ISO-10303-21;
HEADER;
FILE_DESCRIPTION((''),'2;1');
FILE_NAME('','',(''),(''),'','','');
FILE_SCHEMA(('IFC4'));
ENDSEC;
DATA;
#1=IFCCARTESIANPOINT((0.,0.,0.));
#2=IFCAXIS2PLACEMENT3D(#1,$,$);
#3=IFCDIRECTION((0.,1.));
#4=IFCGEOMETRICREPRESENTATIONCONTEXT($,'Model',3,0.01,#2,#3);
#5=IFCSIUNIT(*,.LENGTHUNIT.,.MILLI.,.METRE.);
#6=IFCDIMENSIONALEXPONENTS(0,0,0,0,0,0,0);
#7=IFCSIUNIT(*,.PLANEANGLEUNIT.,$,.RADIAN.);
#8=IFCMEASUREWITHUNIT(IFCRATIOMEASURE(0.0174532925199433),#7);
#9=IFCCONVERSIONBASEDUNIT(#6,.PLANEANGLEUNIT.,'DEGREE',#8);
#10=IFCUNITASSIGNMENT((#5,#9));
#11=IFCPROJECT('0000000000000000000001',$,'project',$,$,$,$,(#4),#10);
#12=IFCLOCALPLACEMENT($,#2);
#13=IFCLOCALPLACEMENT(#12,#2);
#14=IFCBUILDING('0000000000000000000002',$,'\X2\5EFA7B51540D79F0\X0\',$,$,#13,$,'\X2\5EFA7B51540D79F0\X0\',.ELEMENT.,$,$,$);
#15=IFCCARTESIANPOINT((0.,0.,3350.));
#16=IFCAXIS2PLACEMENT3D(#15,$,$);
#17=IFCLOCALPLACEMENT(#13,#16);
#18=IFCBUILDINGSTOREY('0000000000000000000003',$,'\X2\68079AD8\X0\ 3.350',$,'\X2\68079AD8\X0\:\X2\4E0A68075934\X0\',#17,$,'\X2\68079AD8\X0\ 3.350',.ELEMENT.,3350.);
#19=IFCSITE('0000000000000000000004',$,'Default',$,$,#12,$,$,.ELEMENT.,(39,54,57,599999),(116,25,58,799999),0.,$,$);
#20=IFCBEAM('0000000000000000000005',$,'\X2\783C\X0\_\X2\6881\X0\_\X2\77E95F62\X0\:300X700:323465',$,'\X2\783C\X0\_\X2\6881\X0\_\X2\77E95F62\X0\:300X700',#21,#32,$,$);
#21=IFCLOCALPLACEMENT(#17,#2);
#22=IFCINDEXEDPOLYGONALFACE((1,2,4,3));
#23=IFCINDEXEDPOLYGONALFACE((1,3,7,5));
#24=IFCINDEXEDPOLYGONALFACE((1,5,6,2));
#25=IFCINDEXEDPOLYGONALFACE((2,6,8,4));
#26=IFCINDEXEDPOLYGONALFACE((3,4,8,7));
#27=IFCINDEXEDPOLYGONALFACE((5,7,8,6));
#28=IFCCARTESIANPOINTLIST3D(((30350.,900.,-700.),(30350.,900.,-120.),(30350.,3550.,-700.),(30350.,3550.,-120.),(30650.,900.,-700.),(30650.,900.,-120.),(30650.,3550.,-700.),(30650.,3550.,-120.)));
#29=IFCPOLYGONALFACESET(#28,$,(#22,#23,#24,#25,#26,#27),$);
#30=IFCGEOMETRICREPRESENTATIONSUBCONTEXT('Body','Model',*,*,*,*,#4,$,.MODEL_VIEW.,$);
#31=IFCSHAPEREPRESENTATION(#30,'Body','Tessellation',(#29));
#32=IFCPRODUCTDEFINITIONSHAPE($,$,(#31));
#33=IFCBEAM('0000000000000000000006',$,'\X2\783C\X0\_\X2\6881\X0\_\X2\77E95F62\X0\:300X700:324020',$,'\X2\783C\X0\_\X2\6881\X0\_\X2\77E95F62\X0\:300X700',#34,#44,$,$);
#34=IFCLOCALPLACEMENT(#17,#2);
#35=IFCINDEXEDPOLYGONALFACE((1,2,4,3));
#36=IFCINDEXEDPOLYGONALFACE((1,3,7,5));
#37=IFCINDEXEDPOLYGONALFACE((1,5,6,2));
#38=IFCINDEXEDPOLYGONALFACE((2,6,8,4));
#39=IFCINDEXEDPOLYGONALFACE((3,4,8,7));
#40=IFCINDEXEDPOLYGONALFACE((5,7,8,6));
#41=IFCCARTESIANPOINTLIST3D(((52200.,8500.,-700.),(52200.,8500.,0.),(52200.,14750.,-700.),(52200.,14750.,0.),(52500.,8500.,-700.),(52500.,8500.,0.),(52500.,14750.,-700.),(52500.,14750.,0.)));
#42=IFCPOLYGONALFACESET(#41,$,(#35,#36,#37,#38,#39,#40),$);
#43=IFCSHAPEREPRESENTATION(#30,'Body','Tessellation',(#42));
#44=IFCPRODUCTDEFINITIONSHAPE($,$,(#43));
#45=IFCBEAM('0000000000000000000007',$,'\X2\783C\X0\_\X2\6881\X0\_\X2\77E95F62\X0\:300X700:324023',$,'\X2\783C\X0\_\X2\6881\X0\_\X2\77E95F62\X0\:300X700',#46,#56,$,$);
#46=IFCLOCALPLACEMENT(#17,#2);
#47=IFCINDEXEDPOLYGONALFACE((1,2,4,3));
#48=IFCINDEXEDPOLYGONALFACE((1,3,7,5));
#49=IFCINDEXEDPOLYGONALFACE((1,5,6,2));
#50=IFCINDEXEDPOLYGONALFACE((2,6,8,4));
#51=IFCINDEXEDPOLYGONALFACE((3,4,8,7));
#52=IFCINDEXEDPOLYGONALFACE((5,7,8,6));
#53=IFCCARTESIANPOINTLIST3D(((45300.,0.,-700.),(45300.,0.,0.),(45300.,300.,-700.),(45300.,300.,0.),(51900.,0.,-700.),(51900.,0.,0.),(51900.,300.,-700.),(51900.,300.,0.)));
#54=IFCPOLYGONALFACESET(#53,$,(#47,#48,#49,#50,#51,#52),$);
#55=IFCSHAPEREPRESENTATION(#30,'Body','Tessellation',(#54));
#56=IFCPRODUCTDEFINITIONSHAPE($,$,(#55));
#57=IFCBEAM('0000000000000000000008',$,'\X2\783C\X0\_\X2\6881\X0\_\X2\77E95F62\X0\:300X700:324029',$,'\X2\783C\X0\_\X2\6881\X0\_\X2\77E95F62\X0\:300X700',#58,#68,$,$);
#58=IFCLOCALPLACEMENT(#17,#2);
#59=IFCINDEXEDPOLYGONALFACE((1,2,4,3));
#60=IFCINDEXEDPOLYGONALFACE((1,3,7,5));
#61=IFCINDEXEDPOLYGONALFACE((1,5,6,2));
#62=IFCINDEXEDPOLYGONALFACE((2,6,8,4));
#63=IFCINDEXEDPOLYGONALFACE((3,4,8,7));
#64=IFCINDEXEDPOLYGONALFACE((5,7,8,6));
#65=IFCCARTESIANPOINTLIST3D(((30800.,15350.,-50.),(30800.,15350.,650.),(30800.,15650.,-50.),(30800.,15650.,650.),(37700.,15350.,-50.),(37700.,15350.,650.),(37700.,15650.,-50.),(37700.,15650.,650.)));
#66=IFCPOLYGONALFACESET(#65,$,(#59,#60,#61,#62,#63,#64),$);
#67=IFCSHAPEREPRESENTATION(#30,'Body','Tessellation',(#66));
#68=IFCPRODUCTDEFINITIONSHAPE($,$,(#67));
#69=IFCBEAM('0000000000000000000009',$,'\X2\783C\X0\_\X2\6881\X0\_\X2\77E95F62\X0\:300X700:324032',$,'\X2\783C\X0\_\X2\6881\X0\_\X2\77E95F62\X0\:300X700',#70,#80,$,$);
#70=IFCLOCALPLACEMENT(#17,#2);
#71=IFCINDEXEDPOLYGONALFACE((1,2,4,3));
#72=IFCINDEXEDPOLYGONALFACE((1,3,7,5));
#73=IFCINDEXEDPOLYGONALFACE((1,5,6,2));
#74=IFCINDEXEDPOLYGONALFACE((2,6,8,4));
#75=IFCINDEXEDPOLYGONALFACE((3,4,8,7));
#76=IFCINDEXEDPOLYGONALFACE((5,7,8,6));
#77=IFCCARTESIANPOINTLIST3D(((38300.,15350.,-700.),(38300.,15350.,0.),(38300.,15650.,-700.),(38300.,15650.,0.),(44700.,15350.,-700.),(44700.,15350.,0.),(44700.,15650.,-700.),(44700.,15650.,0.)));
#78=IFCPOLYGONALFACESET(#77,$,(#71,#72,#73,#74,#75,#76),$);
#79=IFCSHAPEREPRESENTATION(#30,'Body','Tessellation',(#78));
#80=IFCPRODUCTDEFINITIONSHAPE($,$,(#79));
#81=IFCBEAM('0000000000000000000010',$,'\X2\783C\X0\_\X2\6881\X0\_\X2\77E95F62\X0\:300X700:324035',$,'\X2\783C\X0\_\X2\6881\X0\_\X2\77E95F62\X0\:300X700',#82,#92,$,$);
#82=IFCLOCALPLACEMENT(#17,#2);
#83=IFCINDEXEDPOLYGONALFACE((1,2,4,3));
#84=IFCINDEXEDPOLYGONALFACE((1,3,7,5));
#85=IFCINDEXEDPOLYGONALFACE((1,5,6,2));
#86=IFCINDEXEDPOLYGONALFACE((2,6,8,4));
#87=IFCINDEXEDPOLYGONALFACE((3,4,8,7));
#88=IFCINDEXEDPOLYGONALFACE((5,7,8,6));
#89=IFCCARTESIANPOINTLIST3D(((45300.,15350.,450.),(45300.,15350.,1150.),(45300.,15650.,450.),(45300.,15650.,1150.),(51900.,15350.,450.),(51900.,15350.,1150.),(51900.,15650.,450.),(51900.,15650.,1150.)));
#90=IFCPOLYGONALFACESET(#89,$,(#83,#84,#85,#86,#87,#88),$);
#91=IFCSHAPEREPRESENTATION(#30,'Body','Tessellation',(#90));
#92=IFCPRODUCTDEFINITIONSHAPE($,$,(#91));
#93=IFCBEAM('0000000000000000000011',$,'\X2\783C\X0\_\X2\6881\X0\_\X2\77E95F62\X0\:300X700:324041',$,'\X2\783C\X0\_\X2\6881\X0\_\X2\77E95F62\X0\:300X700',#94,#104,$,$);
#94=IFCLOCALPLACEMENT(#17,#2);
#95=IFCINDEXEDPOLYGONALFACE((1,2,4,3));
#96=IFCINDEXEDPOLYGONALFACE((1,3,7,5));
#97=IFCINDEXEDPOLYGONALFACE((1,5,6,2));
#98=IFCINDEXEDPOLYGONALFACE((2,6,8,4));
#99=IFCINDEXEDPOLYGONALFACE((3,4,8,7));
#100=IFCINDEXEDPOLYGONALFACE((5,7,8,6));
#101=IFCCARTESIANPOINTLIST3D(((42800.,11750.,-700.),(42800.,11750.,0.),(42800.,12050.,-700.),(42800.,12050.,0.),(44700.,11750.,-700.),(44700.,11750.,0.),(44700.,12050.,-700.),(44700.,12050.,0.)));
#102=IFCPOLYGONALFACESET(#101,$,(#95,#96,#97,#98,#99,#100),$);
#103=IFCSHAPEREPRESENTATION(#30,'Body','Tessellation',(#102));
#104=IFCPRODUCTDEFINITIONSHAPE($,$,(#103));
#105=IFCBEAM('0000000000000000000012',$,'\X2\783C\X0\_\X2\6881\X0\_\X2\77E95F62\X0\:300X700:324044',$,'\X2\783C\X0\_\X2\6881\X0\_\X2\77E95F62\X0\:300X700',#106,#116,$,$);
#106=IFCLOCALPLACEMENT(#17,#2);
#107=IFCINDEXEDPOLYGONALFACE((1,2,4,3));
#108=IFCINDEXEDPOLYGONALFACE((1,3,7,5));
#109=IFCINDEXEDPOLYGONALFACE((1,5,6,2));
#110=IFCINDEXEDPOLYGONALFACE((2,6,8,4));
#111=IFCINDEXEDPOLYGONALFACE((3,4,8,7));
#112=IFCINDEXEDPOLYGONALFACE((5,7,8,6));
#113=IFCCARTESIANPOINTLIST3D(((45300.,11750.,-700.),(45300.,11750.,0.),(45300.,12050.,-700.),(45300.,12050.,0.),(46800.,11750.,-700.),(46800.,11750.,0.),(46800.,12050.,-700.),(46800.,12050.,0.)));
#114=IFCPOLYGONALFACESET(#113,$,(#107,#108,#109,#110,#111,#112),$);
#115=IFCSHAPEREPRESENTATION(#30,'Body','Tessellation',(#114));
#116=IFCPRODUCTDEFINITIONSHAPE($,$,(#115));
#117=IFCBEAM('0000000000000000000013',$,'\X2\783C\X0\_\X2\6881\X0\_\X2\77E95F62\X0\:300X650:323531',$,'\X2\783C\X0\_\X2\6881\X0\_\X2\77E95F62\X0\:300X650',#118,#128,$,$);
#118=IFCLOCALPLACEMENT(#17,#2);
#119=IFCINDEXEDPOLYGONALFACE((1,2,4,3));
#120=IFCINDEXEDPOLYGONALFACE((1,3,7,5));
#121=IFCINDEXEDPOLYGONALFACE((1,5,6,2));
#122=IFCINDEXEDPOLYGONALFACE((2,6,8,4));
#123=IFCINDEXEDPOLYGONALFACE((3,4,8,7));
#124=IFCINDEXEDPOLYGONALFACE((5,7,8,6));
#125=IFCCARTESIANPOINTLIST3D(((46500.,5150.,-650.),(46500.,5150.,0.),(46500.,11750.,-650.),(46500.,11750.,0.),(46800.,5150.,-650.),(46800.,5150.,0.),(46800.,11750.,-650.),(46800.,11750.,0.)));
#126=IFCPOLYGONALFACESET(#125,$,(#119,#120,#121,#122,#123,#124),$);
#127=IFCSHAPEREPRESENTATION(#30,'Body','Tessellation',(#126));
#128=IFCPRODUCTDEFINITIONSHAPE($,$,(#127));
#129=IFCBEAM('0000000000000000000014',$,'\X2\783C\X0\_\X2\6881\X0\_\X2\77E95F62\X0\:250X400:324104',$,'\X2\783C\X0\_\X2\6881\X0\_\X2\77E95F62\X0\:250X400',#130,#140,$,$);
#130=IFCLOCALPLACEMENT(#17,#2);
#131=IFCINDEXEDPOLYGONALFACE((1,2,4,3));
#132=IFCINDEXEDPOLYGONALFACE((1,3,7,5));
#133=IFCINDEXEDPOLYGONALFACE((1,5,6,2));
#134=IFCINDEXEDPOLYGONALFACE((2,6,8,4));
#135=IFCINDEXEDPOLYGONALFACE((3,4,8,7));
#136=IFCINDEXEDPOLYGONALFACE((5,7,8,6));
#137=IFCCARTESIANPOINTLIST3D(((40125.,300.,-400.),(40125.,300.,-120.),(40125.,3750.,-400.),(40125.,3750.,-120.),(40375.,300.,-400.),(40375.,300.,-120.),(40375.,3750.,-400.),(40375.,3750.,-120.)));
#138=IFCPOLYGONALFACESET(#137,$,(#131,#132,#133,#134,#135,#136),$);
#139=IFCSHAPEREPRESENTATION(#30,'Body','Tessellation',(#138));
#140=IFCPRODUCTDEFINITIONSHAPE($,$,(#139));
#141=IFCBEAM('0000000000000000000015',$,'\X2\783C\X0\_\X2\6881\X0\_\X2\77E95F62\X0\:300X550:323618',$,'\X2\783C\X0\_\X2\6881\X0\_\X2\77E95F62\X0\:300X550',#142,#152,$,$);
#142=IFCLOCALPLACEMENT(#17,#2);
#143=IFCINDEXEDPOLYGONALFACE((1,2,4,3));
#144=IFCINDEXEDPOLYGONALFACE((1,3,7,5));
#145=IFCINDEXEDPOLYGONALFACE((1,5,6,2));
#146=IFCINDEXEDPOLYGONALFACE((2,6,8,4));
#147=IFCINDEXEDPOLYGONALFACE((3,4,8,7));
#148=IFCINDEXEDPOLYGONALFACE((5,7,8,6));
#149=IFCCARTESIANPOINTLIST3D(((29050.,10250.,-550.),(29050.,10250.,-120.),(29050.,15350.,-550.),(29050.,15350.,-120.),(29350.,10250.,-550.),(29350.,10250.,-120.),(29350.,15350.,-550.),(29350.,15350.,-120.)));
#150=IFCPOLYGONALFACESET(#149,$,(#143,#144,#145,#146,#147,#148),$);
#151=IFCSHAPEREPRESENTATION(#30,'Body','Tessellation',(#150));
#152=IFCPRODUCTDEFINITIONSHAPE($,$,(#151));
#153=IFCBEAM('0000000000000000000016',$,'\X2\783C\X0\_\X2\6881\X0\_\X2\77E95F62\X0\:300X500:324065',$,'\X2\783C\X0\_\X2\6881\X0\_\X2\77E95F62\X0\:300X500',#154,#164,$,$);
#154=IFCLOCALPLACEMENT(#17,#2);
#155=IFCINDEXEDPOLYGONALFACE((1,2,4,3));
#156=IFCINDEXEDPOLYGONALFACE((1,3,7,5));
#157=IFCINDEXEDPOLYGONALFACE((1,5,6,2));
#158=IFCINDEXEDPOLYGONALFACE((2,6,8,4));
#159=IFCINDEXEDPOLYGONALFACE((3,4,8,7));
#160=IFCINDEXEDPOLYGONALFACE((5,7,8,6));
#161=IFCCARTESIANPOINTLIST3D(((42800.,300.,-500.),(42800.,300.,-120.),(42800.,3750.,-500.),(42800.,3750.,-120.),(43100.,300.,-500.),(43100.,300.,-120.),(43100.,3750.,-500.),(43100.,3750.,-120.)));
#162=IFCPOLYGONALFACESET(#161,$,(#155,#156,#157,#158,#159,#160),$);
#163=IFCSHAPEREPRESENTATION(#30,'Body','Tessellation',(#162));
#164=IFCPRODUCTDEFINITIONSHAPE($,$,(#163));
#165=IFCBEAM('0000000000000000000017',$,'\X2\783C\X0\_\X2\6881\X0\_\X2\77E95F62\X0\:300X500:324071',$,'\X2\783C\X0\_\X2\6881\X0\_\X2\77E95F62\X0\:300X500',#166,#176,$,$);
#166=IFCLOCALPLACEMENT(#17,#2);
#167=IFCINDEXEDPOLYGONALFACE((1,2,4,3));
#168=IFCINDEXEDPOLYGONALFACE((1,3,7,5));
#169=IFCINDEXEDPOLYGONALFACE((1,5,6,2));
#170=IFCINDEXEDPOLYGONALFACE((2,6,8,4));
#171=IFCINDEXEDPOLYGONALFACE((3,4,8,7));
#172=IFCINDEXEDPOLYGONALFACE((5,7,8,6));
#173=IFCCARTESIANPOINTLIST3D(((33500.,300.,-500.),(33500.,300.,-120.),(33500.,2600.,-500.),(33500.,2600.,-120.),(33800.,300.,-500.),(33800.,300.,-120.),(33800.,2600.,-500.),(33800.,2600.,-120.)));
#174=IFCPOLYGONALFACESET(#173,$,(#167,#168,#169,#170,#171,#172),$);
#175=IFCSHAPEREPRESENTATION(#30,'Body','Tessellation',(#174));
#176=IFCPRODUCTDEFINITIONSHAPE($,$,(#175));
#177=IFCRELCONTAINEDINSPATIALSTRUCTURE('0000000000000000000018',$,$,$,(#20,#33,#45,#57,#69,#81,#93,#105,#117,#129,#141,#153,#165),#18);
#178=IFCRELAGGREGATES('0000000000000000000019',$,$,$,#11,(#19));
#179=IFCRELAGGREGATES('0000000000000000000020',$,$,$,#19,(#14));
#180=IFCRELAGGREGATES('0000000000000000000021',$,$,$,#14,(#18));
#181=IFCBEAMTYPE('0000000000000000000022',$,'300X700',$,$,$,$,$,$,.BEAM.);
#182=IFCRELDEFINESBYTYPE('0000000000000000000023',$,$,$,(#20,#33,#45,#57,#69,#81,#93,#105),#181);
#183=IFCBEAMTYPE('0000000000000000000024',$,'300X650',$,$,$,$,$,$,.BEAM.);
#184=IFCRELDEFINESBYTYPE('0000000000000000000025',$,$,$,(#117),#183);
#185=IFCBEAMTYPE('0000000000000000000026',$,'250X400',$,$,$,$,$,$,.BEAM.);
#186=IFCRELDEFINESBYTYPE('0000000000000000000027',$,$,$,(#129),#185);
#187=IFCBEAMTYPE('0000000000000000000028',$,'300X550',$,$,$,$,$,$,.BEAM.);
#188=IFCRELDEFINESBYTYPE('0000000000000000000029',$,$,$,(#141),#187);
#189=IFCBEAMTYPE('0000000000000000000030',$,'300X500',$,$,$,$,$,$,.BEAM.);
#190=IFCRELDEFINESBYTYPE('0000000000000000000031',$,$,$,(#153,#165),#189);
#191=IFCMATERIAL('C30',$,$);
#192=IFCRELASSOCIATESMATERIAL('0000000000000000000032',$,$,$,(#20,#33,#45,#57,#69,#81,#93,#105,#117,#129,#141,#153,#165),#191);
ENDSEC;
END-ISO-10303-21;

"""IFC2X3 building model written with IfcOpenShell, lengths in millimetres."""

from ifc_helpers import new_model, entity, si_unit, converted_unit, direction, frame, frame_2d, origin, origin_2d_with_axis, place, context, subcontext, project, spatial, rectangle, extrude, material, type_object, element, save


model = new_model("IFC2X3")

# Units and contexts
model_context = context("Model", 3, precision=0.01, world=origin(), true_north=direction((0.0, 1.0)))
body_context = subcontext(model_context, "Body", "Model", "MODEL_VIEW")
ifc_project = project(units=[si_unit("LENGTHUNIT", "METRE", prefix="MILLI"), converted_unit("PLANEANGLEUNIT", "DEGREE", entity("IfcRatioMeasure", 0.0174532925199433), si_unit("PLANEANGLEUNIT", "RADIAN"), dimensions=[0, 0, 0, 0, 0, 0, 0])], contexts=[model_context])

# Site, building, storey
site_placement = place(None, origin())
site = spatial("IfcSite", under=ifc_project, at=site_placement, Name="Default", CompositionType="ELEMENT", RefLatitude=(39, 54, 57, 599999), RefLongitude=(116, 25, 58, 799999), RefElevation=0.0)
building_placement = place(site_placement, origin())
building = spatial("IfcBuilding", under=site, at=building_placement, Name="建筑名称", LongName="建筑名称", CompositionType="ELEMENT")
storey_placement = place(building_placement, frame((0.0, 0.0, 3350.0)))
storey = spatial("IfcBuildingStorey", under=building, at=storey_placement, Name="标高 3.350", ObjectType="标高:上标头", LongName="标高 3.350", CompositionType="ELEMENT", Elevation=3350.0)

# Beams
ifc_material_1 = material(Name="C30")
beam_type_1 = type_object("IfcBeamType", Name="300X700", PredefinedType="BEAM")
beam_1_placement = place(storey_placement, frame((30500.0, 150.0, 0.0), z_axis=(0.0, 0.0, 1.0), x_axis=(0.0, 1.0, 0.0)))
element("IfcBeam", 1, at=beam_1_placement, inside=storey, type_object=beam_type_1, material=ifc_material_1, Name="砼_梁_矩形:300X700:323465", ObjectType="砼_梁_矩形:300X700", context=body_context, shape_type="SweptSolid", body=[
    extrude(rectangle(XDim=580.0, YDim=300.0, at=frame_2d((0.0, 0.0), x_axis=(1.0, 0.0))), frame((750.0, 0.0, -410.0), z_axis=(1.0, 0.0, 0.0), x_axis=(0.0, 0.0, -1.0)), (0.0, 0.0, 1.0), 2650.0),
])
beam_2_placement = place(storey_placement, frame((52500.0, 8150.0, 0.0), z_axis=(0.0, 0.0, 1.0), x_axis=(0.0, 1.0, 0.0)))
element("IfcBeam", 2, at=beam_2_placement, inside=storey, type_object=beam_type_1, material=ifc_material_1, Name="砼_梁_矩形:300X700:324020", ObjectType="砼_梁_矩形:300X700", context=body_context, shape_type="SweptSolid", body=[
    extrude(rectangle(XDim=700.0, YDim=300.0, at=origin_2d_with_axis()), frame((350.0, 150.0, -350.0), z_axis=(1.0, 0.0, 0.0), x_axis=(0.0, 0.0, -1.0)), (0.0, 0.0, 1.0), 6250.0),
])
beam_3_placement = place(storey_placement, frame((45000.0, 0.0, 0.0)))
element("IfcBeam", 3, at=beam_3_placement, inside=storey, type_object=beam_type_1, material=ifc_material_1, Name="砼_梁_矩形:300X700:324023", ObjectType="砼_梁_矩形:300X700", context=body_context, shape_type="SweptSolid", body=[
    extrude(rectangle(XDim=700.0, YDim=300.0, at=origin_2d_with_axis()), frame((300.0, 150.0, -350.0), z_axis=(1.0, 0.0, 0.0), x_axis=(0.0, 0.0, -1.0)), (0.0, 0.0, 1.0), 6600.0),
])
beam_4_placement = place(storey_placement, frame((30500.0, 15650.0, 0.0)))
element("IfcBeam", 4, at=beam_4_placement, inside=storey, type_object=beam_type_1, material=ifc_material_1, Name="砼_梁_矩形:300X700:324029", ObjectType="砼_梁_矩形:300X700", context=body_context, shape_type="SweptSolid", body=[
    extrude(rectangle(XDim=700.0, YDim=300.0, at=frame_2d((0.0, 0.0), x_axis=(1.0, 0.0))), frame((300.0, -150.0, 300.0), z_axis=(1.0, 0.0, 0.0), x_axis=(0.0, 0.0, -1.0)), (0.0, 0.0, 1.0), 6900.0),
])
beam_5_placement = place(storey_placement, frame((38000.0, 15650.0, 0.0)))
element("IfcBeam", 5, at=beam_5_placement, inside=storey, type_object=beam_type_1, material=ifc_material_1, Name="砼_梁_矩形:300X700:324032", ObjectType="砼_梁_矩形:300X700", context=body_context, shape_type="SweptSolid", body=[
    extrude(rectangle(XDim=700.0, YDim=300.0, at=origin_2d_with_axis()), frame((300.0, -150.0, -350.0), z_axis=(1.0, 0.0, 0.0), x_axis=(0.0, 0.0, -1.0)), (0.0, 0.0, 1.0), 6400.0),
])
beam_6_placement = place(storey_placement, frame((45000.0, 15650.0, 0.0)))
element("IfcBeam", 6, at=beam_6_placement, inside=storey, type_object=beam_type_1, material=ifc_material_1, Name="砼_梁_矩形:300X700:324035", ObjectType="砼_梁_矩形:300X700", context=body_context, shape_type="SweptSolid", body=[
    extrude(rectangle(XDim=700.0, YDim=300.0, at=frame_2d((0.0, 0.0), x_axis=(1.0, 0.0))), frame((300.0, -150.0, 800.0), z_axis=(1.0, 0.0, 0.0), x_axis=(0.0, 0.0, -1.0)), (0.0, 0.0, 1.0), 6600.0),
])
beam_7_placement = place(storey_placement, frame((42800.0, 12050.0, 0.0)))
element("IfcBeam", 7, at=beam_7_placement, inside=storey, type_object=beam_type_1, material=ifc_material_1, Name="砼_梁_矩形:300X700:324041", ObjectType="砼_梁_矩形:300X700", context=body_context, shape_type="SweptSolid", body=[
    extrude(rectangle(XDim=700.0, YDim=300.0, at=frame_2d((0.0, 0.0), x_axis=(1.0, 0.0))), frame((0.0, -150.0, -350.0), z_axis=(1.0, 0.0, 0.0), x_axis=(0.0, 0.0, -1.0)), (0.0, 0.0, 1.0), 1900.0),
])
beam_8_placement = place(storey_placement, frame((45000.0, 12050.0, 0.0)))
element("IfcBeam", 8, at=beam_8_placement, inside=storey, type_object=beam_type_1, material=ifc_material_1, Name="砼_梁_矩形:300X700:324044", ObjectType="砼_梁_矩形:300X700", context=body_context, shape_type="SweptSolid", body=[
    extrude(rectangle(XDim=700.0, YDim=300.0, at=frame_2d((0.0, 0.0), x_axis=(1.0, 0.0))), frame((300.0, -150.0, -350.0), z_axis=(1.0, 0.0, 0.0), x_axis=(0.0, 0.0, -1.0)), (0.0, 0.0, 1.0), 1500.0),
])
beam_type_2 = type_object("IfcBeamType", Name="300X650", PredefinedType="BEAM")
beam_9_placement = place(storey_placement, frame((46800.0, 4850.0, 0.0), z_axis=(0.0, 0.0, 1.0), x_axis=(0.0, 1.0, 0.0)))
element("IfcBeam", 9, at=beam_9_placement, inside=storey, type_object=beam_type_2, material=ifc_material_1, Name="砼_梁_矩形:300X650:323531", ObjectType="砼_梁_矩形:300X650", context=body_context, shape_type="SweptSolid", body=[
    extrude(rectangle(XDim=650.0, YDim=300.0, at=origin_2d_with_axis()), frame((300.0, 150.0, -325.0), z_axis=(1.0, 0.0, 0.0), x_axis=(0.0, 0.0, -1.0)), (0.0, 0.0, 1.0), 6600.0),
])
beam_type_3 = type_object("IfcBeamType", Name="250X400", PredefinedType="BEAM")
beam_10_placement = place(storey_placement, frame((40250.0, 0.0, 0.0), z_axis=(0.0, 0.0, 1.0), x_axis=(0.0, 1.0, 0.0)))
element("IfcBeam", 10, at=beam_10_placement, inside=storey, type_object=beam_type_3, material=ifc_material_1, Name="砼_梁_矩形:250X400:324104", ObjectType="砼_梁_矩形:250X400", context=body_context, shape_type="SweptSolid", body=[
    extrude(rectangle(XDim=280.0, YDim=250.0, at=frame_2d((0.0, 0.0), x_axis=(1.0, 0.0))), frame((300.0, 0.0, -260.0), z_axis=(1.0, 0.0, 0.0), x_axis=(0.0, 0.0, -1.0)), (0.0, 0.0, 1.0), 3450.0),
])
beam_type_4 = type_object("IfcBeamType", Name="300X550", PredefinedType="BEAM")
beam_11_placement = place(storey_placement, frame((29350.0, 9950.0, 0.0), z_axis=(0.0, 0.0, 1.0), x_axis=(0.0, 1.0, 0.0)))
element("IfcBeam", 11, at=beam_11_placement, inside=storey, type_object=beam_type_4, material=ifc_material_1, Name="砼_梁_矩形:300X550:323618", ObjectType="砼_梁_矩形:300X550", context=body_context, shape_type="SweptSolid", body=[
    extrude(rectangle(XDim=430.0, YDim=300.0, at=frame_2d((0.0, 0.0), x_axis=(1.0, 0.0))), frame((300.0, 150.0, -335.0), z_axis=(1.0, 0.0, 0.0), x_axis=(0.0, 0.0, -1.0)), (0.0, 0.0, 1.0), 5100.0),
])
beam_type_5 = type_object("IfcBeamType", Name="300X500", PredefinedType="BEAM")
beam_12_placement = place(storey_placement, frame((42800.0, 0.0, 0.0), z_axis=(0.0, 0.0, 1.0), x_axis=(0.0, 1.0, 0.0)))
element("IfcBeam", 12, at=beam_12_placement, inside=storey, type_object=beam_type_5, material=ifc_material_1, Name="砼_梁_矩形:300X500:324065", ObjectType="砼_梁_矩形:300X500", context=body_context, shape_type="SweptSolid", body=[
    extrude(rectangle(XDim=380.0, YDim=300.0, at=frame_2d((0.0, 0.0), x_axis=(1.0, 0.0))), frame((300.0, -150.0, -310.0), z_axis=(1.0, 0.0, 0.0), x_axis=(0.0, 0.0, -1.0)), (0.0, 0.0, 1.0), 3450.0),
])
beam_13_placement = place(storey_placement, frame((33800.0, 0.0, 0.0), z_axis=(0.0, 0.0, 1.0), x_axis=(0.0, 1.0, 0.0)))
element("IfcBeam", 13, at=beam_13_placement, inside=storey, type_object=beam_type_5, material=ifc_material_1, Name="砼_梁_矩形:300X500:324071", ObjectType="砼_梁_矩形:300X500", context=body_context, shape_type="SweptSolid", body=[
    extrude(rectangle(XDim=380.0, YDim=300.0, at=frame_2d((0.0, 0.0), x_axis=(1.0, 0.0))), frame((300.0, 150.0, -310.0), z_axis=(1.0, 0.0, 0.0), x_axis=(0.0, 0.0, -1.0)), (0.0, 0.0, 1.0), 2300.0),
])

save(model, "model.ifc")
